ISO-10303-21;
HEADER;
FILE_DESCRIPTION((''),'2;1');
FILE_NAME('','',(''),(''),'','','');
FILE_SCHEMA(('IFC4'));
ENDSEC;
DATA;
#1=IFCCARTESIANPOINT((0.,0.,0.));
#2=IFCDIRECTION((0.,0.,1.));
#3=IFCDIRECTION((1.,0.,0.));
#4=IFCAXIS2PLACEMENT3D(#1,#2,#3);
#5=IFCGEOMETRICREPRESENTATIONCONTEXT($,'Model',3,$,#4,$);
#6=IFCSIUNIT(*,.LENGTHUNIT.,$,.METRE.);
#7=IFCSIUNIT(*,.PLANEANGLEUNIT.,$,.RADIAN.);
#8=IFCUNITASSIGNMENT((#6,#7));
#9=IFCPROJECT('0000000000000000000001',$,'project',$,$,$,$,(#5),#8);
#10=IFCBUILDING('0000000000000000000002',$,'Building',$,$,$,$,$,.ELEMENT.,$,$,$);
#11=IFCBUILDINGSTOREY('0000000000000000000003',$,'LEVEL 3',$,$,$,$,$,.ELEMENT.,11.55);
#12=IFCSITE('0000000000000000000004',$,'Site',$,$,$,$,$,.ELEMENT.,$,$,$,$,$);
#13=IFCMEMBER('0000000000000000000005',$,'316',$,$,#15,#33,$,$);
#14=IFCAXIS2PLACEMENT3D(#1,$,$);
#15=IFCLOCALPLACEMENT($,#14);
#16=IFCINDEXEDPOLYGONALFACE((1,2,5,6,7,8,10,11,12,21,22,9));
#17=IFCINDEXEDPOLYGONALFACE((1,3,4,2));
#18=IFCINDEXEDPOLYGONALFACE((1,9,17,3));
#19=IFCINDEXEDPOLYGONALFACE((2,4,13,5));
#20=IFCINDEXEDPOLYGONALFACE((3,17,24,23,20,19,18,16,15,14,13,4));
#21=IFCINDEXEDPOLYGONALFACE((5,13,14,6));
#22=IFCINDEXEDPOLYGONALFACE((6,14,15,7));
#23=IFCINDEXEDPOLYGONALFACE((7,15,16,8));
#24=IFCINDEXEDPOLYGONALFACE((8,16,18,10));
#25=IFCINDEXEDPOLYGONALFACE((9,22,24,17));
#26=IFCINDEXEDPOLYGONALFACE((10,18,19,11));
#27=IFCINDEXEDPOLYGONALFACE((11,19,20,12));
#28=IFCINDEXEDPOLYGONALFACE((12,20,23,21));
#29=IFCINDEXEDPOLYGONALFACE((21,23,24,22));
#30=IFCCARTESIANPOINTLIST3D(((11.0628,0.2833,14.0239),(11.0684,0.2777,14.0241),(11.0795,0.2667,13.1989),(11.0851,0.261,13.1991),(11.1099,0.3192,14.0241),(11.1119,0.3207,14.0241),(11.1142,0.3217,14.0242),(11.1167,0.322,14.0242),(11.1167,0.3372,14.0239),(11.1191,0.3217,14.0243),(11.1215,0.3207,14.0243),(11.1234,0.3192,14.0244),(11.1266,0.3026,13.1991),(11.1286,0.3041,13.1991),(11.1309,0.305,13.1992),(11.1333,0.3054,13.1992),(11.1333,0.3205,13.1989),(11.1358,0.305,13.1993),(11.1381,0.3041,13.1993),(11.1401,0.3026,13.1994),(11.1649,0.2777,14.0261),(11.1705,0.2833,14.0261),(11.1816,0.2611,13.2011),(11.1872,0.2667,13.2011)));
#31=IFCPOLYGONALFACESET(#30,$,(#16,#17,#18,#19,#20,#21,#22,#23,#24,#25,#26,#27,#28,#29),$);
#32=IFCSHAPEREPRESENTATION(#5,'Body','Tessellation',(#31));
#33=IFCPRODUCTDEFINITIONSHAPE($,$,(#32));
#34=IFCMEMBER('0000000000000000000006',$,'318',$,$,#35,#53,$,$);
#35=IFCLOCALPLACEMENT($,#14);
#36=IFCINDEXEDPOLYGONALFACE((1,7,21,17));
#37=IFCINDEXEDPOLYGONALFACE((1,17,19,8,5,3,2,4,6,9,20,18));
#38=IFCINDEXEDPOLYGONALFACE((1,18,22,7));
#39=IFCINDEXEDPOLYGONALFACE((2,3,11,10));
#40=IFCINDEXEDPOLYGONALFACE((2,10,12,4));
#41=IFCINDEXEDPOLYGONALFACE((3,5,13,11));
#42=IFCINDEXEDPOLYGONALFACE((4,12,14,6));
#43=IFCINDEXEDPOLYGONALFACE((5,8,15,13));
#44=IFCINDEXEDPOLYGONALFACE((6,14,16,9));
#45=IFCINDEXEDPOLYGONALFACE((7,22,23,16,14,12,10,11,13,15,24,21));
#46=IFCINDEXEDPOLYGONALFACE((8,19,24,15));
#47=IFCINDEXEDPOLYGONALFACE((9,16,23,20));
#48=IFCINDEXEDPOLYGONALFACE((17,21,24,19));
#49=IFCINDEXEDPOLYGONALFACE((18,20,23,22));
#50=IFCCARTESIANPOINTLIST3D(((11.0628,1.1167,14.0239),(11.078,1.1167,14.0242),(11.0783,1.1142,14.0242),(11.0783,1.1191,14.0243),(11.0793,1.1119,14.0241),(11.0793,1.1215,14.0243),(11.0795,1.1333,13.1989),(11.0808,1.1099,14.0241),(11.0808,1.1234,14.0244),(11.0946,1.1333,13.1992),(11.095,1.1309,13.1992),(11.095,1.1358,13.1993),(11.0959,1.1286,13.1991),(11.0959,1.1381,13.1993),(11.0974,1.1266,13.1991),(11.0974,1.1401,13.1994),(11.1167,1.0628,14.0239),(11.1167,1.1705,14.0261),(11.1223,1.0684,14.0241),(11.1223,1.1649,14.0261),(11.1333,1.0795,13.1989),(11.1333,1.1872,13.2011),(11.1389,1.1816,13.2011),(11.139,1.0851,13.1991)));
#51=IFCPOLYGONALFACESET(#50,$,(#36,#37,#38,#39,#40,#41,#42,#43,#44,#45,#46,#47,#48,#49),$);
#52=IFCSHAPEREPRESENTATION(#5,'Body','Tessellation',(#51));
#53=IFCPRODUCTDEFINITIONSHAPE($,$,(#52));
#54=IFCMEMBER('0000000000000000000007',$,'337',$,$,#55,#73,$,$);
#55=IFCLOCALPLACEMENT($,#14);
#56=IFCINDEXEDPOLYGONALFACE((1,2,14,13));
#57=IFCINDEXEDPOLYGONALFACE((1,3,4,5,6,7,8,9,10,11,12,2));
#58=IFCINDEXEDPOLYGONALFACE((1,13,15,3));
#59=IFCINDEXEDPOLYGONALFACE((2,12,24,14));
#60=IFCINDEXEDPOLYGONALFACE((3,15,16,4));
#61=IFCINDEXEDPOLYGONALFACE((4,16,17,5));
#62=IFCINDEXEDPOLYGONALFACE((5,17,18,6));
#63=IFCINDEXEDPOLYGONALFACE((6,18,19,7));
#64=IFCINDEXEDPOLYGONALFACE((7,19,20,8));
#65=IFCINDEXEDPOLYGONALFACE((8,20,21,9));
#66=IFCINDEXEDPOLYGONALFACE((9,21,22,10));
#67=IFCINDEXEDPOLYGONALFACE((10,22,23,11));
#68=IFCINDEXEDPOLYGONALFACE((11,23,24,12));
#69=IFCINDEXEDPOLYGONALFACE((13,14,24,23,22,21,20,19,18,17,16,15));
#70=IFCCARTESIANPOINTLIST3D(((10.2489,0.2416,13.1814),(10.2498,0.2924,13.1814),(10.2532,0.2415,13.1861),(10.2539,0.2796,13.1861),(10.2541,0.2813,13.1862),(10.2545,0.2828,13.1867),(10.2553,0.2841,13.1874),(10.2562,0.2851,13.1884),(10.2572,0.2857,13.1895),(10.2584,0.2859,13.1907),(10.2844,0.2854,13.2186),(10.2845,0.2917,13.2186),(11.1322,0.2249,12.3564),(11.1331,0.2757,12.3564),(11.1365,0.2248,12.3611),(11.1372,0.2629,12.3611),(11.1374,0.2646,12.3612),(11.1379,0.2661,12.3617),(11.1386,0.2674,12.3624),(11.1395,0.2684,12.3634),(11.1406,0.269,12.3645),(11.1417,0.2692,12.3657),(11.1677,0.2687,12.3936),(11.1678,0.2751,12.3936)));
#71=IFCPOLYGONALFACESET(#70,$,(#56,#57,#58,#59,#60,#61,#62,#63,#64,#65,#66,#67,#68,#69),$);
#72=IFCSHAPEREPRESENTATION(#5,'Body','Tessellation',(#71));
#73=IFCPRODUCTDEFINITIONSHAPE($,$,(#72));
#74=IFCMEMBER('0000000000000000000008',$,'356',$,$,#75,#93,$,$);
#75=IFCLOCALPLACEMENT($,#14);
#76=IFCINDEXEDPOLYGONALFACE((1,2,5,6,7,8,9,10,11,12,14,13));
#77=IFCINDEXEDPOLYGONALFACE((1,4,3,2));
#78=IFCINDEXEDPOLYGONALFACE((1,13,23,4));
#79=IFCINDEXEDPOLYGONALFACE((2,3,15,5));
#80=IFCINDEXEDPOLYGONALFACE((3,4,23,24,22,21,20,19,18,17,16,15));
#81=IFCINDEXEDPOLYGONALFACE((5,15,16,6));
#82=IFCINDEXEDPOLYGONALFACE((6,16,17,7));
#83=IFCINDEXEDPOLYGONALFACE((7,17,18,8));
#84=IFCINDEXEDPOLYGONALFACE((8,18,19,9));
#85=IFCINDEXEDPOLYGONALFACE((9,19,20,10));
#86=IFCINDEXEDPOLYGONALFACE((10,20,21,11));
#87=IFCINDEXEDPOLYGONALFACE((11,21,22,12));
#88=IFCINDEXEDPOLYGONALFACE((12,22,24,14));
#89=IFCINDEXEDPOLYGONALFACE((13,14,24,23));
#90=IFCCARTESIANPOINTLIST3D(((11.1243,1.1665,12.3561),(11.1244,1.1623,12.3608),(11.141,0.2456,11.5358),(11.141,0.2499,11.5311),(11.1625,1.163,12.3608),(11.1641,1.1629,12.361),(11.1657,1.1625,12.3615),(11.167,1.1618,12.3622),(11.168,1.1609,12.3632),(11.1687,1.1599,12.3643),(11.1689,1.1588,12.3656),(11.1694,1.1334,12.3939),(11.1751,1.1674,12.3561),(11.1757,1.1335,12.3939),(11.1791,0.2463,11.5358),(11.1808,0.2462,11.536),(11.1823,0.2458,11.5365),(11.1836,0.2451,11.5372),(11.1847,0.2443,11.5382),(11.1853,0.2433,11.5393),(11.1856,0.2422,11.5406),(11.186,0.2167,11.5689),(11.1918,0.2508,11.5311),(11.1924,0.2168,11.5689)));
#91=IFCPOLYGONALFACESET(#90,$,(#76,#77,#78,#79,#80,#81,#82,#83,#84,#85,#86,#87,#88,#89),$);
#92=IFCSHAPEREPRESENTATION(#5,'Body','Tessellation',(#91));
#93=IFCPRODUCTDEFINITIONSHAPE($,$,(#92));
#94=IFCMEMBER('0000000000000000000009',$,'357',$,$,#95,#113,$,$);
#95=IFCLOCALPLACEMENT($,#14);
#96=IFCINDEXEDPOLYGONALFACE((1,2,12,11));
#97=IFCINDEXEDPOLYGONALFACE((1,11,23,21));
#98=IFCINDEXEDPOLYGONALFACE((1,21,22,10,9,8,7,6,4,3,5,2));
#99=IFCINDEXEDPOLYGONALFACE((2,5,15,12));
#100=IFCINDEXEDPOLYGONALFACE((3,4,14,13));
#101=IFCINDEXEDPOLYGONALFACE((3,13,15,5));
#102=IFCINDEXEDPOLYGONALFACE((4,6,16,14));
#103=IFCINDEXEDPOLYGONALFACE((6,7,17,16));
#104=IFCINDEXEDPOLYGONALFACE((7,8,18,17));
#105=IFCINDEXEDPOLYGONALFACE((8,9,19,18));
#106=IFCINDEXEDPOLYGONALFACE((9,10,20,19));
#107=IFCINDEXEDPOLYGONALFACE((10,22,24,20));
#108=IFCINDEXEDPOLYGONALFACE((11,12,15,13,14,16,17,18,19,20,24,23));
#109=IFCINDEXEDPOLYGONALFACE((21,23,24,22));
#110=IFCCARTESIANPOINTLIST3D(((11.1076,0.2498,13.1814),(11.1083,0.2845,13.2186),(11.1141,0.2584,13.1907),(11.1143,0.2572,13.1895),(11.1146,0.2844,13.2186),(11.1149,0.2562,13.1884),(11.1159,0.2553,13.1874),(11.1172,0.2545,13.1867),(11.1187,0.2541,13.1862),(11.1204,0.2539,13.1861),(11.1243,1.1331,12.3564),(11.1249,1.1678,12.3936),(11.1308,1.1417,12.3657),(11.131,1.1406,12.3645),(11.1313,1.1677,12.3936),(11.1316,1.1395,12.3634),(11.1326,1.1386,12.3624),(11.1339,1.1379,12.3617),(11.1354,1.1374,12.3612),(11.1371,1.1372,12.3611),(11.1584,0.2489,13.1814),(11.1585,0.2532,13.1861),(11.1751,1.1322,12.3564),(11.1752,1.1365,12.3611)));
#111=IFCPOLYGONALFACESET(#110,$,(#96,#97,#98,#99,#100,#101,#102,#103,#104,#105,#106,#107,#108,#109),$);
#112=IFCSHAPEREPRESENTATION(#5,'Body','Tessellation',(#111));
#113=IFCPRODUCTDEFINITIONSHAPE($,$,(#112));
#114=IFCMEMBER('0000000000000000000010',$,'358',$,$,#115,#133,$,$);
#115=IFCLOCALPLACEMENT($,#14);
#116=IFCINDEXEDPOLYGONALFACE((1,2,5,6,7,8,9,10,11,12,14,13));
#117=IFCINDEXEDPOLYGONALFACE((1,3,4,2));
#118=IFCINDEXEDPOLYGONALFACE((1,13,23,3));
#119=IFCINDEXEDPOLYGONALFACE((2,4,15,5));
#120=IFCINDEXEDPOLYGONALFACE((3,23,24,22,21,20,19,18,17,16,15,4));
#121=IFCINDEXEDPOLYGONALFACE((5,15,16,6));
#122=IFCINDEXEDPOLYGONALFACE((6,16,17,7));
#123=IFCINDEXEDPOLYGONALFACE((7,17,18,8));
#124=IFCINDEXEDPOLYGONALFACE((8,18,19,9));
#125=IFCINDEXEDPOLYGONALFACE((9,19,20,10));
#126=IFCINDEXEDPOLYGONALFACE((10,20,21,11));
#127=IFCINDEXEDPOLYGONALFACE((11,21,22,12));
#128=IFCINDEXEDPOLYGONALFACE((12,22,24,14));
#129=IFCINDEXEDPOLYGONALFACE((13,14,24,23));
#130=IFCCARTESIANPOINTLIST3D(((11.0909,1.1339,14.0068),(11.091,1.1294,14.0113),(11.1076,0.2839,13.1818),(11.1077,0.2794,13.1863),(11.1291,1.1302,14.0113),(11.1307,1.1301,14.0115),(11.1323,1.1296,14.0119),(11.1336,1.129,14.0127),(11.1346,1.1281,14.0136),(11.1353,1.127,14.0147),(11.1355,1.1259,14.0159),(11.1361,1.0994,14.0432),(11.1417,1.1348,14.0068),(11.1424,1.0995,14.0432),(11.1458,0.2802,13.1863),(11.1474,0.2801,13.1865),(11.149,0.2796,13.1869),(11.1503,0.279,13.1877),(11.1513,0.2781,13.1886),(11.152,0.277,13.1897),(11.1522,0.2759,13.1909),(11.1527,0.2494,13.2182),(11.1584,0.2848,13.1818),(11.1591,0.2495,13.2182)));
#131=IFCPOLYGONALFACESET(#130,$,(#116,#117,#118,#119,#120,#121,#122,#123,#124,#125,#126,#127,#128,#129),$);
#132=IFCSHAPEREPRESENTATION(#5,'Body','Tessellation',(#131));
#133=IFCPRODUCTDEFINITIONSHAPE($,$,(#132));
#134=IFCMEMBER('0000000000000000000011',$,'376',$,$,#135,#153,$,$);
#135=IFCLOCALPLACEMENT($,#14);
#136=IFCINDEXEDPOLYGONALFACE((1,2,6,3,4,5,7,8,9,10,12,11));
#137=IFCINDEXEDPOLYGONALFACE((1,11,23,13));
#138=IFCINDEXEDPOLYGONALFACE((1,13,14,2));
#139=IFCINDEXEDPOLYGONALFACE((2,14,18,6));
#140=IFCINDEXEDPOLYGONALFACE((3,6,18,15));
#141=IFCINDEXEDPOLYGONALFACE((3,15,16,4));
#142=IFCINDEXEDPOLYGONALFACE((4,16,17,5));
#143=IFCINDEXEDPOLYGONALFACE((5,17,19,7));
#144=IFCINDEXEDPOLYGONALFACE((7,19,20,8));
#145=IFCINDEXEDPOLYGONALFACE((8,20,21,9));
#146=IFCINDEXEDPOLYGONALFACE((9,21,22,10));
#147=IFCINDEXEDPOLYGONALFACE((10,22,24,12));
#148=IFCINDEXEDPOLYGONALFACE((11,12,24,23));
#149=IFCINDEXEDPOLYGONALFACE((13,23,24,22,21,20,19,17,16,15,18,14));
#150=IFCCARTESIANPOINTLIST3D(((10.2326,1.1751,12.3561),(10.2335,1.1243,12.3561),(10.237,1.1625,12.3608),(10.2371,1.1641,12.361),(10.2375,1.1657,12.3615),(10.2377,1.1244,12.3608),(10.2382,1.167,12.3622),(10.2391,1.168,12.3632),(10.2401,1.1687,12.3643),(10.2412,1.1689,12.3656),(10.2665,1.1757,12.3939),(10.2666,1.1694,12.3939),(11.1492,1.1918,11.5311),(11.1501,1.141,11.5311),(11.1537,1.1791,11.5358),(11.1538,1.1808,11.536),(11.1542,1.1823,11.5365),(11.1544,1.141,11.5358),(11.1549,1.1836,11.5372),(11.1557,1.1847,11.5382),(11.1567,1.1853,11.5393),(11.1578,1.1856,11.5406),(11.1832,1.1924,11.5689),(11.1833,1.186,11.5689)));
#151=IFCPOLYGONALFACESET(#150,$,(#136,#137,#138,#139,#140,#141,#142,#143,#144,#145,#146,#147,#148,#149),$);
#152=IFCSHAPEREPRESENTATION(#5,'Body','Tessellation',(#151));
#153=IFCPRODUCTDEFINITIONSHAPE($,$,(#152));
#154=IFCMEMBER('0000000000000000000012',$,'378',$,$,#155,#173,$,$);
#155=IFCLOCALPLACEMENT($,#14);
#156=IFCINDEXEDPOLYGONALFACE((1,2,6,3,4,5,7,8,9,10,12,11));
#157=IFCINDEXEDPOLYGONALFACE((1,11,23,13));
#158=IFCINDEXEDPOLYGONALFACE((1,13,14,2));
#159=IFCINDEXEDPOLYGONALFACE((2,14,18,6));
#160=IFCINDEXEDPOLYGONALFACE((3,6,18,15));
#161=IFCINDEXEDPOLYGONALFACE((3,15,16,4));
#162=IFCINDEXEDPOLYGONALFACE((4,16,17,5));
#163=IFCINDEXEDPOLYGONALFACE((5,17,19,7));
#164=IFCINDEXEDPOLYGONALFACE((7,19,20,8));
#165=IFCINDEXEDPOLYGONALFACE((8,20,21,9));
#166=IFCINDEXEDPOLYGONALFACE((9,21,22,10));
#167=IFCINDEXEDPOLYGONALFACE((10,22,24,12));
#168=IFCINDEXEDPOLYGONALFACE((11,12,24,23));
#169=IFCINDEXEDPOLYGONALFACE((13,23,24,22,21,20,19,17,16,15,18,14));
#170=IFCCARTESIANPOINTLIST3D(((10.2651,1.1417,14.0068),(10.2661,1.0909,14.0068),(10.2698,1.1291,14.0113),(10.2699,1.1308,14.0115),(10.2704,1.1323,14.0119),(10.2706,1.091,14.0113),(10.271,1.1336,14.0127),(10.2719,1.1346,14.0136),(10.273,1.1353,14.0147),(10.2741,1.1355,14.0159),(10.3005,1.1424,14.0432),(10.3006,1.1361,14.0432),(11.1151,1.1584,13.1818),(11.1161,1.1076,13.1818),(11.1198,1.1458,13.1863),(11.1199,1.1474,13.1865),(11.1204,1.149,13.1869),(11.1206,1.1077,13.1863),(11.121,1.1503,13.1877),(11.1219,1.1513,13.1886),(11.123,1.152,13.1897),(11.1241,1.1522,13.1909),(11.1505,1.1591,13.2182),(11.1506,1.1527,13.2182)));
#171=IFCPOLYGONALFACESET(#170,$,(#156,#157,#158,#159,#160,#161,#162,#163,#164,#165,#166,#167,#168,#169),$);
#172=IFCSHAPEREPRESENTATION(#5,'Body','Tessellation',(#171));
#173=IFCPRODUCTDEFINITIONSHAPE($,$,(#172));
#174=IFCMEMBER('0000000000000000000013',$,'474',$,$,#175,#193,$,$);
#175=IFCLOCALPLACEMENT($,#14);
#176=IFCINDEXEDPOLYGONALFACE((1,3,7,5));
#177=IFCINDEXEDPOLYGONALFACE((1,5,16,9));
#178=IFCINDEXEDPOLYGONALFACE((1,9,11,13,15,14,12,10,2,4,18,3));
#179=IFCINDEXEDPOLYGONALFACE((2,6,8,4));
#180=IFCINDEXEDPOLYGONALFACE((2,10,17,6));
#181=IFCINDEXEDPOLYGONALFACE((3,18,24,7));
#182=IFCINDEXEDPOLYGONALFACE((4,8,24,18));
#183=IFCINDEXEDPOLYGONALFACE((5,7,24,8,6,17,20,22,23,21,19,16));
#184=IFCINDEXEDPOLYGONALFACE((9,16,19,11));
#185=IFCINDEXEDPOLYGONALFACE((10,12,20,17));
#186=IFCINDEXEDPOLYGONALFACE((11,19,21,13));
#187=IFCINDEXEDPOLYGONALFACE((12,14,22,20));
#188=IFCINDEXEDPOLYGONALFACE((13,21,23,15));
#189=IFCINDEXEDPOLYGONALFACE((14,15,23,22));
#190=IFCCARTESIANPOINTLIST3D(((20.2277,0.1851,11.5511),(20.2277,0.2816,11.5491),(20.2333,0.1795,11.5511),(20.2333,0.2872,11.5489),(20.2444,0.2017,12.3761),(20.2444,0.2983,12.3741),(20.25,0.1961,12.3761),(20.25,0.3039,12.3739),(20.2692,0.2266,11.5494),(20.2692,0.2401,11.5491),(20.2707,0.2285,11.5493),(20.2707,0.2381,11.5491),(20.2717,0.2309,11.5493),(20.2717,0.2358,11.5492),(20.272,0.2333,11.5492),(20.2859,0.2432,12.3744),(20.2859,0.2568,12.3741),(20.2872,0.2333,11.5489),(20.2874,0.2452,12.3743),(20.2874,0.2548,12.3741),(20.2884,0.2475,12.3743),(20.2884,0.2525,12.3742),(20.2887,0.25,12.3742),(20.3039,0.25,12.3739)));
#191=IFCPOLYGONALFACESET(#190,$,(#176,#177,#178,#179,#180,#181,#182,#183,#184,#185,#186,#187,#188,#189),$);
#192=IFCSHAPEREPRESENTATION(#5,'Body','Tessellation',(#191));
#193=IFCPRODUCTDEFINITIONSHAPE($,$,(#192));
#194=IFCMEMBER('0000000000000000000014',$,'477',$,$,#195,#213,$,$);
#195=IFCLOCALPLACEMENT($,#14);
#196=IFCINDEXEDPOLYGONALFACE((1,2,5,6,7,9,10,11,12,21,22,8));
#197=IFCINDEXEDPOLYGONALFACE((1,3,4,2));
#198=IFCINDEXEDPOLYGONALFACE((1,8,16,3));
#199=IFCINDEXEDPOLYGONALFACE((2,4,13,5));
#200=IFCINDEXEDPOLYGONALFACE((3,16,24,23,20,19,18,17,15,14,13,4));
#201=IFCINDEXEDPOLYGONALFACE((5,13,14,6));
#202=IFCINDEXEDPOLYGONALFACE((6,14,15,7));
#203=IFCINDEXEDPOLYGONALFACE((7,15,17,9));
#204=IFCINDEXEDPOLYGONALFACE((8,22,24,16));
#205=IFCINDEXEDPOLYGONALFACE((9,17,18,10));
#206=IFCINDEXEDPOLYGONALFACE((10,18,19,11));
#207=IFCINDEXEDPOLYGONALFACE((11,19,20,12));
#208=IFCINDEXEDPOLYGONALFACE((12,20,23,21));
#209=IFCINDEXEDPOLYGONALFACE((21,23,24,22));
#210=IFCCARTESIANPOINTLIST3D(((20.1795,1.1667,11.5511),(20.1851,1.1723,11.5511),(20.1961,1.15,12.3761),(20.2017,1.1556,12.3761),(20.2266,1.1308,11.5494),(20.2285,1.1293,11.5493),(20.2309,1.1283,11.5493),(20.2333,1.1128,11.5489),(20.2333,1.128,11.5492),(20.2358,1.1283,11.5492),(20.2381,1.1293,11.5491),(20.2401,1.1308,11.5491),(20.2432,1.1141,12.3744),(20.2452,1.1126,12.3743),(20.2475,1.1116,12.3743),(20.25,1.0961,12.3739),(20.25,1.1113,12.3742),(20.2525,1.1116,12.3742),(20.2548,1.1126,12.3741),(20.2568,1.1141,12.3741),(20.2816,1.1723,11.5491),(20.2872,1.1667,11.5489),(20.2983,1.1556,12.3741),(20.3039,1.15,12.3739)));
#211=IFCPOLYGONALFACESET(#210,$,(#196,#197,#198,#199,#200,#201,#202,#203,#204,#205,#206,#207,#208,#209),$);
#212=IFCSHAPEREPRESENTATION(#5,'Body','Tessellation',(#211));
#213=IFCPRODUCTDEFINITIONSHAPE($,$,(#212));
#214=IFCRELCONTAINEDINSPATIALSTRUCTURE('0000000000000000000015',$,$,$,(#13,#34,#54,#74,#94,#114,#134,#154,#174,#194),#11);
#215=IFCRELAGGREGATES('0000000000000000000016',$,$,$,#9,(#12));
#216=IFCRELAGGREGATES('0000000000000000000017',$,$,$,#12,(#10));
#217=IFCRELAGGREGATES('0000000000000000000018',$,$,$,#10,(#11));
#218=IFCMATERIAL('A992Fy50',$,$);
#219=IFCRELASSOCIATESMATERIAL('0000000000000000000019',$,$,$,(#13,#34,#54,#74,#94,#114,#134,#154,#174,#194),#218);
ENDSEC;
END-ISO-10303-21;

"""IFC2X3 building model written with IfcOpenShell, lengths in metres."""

from ifc_helpers import new_model, si_unit, frame, origin_with_axes, origin_2d_with_axis, place, context, project, spatial, l_section, extrude, material, element, save


model = new_model("IFC2X3")

# Units and contexts
model_context = context("Model", 3, world=origin_with_axes())
ifc_project = project(units=[si_unit("LENGTHUNIT", "METRE"), si_unit("PLANEANGLEUNIT", "RADIAN")], contexts=[model_context])

# Site, building, storey
site = spatial("IfcSite", under=ifc_project, Name="Site", CompositionType="ELEMENT")
building = spatial("IfcBuilding", under=site, Name="Building", CompositionType="ELEMENT")
storey = spatial("IfcBuildingStorey", under=building, Name="LEVEL 3", CompositionType="ELEMENT", Elevation=11.55)

# Shared definitions
ifc_material = material(Name="A992Fy50")

# Members
for number, where, z_axis, x_axis, name in (
    (1, (11.1333, 0.2667, 13.2), (-0.020194, 0.020194, 0.999592), (-0.707107, -0.707107, 0.0), "316"),
    (2, (11.1333, 1.1333, 13.2), (-0.020194, -0.020194, 0.999592), (0.707107, -0.707107, 0.0), "318"),
):
    element("IfcMember", number, at=place(None, frame(where, z_axis=z_axis, x_axis=x_axis)), inside=storey, material=ifc_material, Name=name, context=model_context, shape_type="SweptSolid", body=[
        extrude(l_section(Depth=0.0762, Width=0.0762, Thickness=0.0079, FilletRadius=0.0096, at=origin_2d_with_axis()), origin_with_axes(), (0.0, 0.0, 1.0), 0.8253),
    ])
member_1_placement = place(None, frame((11.15, 0.25, 12.375), z_axis=(-0.730756, 0.013788, 0.682499), x_axis=(-0.018865, -0.999822, 0.0)))
element("IfcMember", 3, at=member_1_placement, inside=storey, material=ifc_material, Name="337", context=model_context, shape_type="SweptSolid", body=[
    extrude(l_section(Depth=0.0508, Width=0.0508, Thickness=0.0063, FilletRadius=0.0063, at=origin_2d_with_axis()), origin_with_axes(), (0.0, 0.0, 1.0), 1.2088),
])
member_2_placement = place(None, frame((11.1667, 0.2333, 11.55), z_axis=(-0.013513, 0.743226, 0.668904), x_axis=(-0.999835, -0.018179, 0.0)))
element("IfcMember", 4, at=member_2_placement, inside=storey, material=ifc_material, Name="356", context=model_context, shape_type="SweptSolid", body=[
    extrude(l_section(Depth=0.0508, Width=0.0508, Thickness=0.0063, FilletRadius=0.0063, at=origin_2d_with_axis()), origin_with_axes(), (0.0, 0.0, 1.0), 1.2334),
])
member_3_placement = place(None, frame((11.15, 1.15, 12.375), z_axis=(-0.013788, -0.730756, 0.682499), x_axis=(0.999822, -0.018865, 0.0)))
element("IfcMember", 5, at=member_3_placement, inside=storey, material=ifc_material, Name="357", context=model_context, shape_type="SweptSolid", body=[
    extrude(l_section(Depth=0.0508, Width=0.0508, Thickness=0.0063, FilletRadius=0.0063, at=origin_2d_with_axis()), origin_with_axes(), (0.0, 0.0, 1.0), 1.2088),
])
member_4_placement = place(None, frame((11.1333, 0.2667, 13.2), z_axis=(-0.014069, 0.71751, 0.696406), x_axis=(-0.999808, -0.019604, 0.0)))
element("IfcMember", 6, at=member_4_placement, inside=storey, material=ifc_material, Name="358", context=model_context, shape_type="SweptSolid", body=[
    extrude(l_section(Depth=0.0508, Width=0.0508, Thickness=0.0063, FilletRadius=0.0063, at=origin_2d_with_axis()), origin_with_axes(), (0.0, 0.0, 1.0), 1.1847),
])
member_5_placement = place(None, frame((11.1667, 1.1667, 11.55), z_axis=(-0.743226, -0.013513, 0.668904), x_axis=(0.018179, -0.999835, 0.0)))
element("IfcMember", 7, at=member_5_placement, inside=storey, material=ifc_material, Name="376", context=model_context, shape_type="SweptSolid", body=[
    extrude(l_section(Depth=0.0508, Width=0.0508, Thickness=0.0063, FilletRadius=0.0063, at=origin_2d_with_axis()), origin_with_axes(), (0.0, 0.0, 1.0), 1.2334),
])
member_6_placement = place(None, frame((11.1333, 1.1333, 13.2), z_axis=(-0.71751, -0.014069, 0.696406), x_axis=(0.019604, -0.999808, 0.0)))
element("IfcMember", 8, at=member_6_placement, inside=storey, material=ifc_material, Name="378", context=model_context, shape_type="SweptSolid", body=[
    extrude(l_section(Depth=0.0508, Width=0.0508, Thickness=0.0063, FilletRadius=0.0063, at=origin_2d_with_axis()), origin_with_axes(), (0.0, 0.0, 1.0), 1.1847),
])
for number, where, z_axis, x_axis, name in (
    (9, (20.2333, 0.2333, 11.55), (0.020194, 0.020194, 0.999592), (-0.707107, 0.707107, 0.0), "474"),
    (10, (20.2333, 1.1667, 11.55), (0.020194, -0.020194, 0.999592), (0.707107, 0.707107, 0.0), "477"),
):
    element("IfcMember", number, at=place(None, frame(where, z_axis=z_axis, x_axis=x_axis)), inside=storey, material=ifc_material, Name=name, context=model_context, shape_type="SweptSolid", body=[
        extrude(l_section(Depth=0.0762, Width=0.0762, Thickness=0.0079, FilletRadius=0.0096, at=origin_2d_with_axis()), origin_with_axes(), (0.0, 0.0, 1.0), 0.8253),
    ])

save(model, "model.ifc")
